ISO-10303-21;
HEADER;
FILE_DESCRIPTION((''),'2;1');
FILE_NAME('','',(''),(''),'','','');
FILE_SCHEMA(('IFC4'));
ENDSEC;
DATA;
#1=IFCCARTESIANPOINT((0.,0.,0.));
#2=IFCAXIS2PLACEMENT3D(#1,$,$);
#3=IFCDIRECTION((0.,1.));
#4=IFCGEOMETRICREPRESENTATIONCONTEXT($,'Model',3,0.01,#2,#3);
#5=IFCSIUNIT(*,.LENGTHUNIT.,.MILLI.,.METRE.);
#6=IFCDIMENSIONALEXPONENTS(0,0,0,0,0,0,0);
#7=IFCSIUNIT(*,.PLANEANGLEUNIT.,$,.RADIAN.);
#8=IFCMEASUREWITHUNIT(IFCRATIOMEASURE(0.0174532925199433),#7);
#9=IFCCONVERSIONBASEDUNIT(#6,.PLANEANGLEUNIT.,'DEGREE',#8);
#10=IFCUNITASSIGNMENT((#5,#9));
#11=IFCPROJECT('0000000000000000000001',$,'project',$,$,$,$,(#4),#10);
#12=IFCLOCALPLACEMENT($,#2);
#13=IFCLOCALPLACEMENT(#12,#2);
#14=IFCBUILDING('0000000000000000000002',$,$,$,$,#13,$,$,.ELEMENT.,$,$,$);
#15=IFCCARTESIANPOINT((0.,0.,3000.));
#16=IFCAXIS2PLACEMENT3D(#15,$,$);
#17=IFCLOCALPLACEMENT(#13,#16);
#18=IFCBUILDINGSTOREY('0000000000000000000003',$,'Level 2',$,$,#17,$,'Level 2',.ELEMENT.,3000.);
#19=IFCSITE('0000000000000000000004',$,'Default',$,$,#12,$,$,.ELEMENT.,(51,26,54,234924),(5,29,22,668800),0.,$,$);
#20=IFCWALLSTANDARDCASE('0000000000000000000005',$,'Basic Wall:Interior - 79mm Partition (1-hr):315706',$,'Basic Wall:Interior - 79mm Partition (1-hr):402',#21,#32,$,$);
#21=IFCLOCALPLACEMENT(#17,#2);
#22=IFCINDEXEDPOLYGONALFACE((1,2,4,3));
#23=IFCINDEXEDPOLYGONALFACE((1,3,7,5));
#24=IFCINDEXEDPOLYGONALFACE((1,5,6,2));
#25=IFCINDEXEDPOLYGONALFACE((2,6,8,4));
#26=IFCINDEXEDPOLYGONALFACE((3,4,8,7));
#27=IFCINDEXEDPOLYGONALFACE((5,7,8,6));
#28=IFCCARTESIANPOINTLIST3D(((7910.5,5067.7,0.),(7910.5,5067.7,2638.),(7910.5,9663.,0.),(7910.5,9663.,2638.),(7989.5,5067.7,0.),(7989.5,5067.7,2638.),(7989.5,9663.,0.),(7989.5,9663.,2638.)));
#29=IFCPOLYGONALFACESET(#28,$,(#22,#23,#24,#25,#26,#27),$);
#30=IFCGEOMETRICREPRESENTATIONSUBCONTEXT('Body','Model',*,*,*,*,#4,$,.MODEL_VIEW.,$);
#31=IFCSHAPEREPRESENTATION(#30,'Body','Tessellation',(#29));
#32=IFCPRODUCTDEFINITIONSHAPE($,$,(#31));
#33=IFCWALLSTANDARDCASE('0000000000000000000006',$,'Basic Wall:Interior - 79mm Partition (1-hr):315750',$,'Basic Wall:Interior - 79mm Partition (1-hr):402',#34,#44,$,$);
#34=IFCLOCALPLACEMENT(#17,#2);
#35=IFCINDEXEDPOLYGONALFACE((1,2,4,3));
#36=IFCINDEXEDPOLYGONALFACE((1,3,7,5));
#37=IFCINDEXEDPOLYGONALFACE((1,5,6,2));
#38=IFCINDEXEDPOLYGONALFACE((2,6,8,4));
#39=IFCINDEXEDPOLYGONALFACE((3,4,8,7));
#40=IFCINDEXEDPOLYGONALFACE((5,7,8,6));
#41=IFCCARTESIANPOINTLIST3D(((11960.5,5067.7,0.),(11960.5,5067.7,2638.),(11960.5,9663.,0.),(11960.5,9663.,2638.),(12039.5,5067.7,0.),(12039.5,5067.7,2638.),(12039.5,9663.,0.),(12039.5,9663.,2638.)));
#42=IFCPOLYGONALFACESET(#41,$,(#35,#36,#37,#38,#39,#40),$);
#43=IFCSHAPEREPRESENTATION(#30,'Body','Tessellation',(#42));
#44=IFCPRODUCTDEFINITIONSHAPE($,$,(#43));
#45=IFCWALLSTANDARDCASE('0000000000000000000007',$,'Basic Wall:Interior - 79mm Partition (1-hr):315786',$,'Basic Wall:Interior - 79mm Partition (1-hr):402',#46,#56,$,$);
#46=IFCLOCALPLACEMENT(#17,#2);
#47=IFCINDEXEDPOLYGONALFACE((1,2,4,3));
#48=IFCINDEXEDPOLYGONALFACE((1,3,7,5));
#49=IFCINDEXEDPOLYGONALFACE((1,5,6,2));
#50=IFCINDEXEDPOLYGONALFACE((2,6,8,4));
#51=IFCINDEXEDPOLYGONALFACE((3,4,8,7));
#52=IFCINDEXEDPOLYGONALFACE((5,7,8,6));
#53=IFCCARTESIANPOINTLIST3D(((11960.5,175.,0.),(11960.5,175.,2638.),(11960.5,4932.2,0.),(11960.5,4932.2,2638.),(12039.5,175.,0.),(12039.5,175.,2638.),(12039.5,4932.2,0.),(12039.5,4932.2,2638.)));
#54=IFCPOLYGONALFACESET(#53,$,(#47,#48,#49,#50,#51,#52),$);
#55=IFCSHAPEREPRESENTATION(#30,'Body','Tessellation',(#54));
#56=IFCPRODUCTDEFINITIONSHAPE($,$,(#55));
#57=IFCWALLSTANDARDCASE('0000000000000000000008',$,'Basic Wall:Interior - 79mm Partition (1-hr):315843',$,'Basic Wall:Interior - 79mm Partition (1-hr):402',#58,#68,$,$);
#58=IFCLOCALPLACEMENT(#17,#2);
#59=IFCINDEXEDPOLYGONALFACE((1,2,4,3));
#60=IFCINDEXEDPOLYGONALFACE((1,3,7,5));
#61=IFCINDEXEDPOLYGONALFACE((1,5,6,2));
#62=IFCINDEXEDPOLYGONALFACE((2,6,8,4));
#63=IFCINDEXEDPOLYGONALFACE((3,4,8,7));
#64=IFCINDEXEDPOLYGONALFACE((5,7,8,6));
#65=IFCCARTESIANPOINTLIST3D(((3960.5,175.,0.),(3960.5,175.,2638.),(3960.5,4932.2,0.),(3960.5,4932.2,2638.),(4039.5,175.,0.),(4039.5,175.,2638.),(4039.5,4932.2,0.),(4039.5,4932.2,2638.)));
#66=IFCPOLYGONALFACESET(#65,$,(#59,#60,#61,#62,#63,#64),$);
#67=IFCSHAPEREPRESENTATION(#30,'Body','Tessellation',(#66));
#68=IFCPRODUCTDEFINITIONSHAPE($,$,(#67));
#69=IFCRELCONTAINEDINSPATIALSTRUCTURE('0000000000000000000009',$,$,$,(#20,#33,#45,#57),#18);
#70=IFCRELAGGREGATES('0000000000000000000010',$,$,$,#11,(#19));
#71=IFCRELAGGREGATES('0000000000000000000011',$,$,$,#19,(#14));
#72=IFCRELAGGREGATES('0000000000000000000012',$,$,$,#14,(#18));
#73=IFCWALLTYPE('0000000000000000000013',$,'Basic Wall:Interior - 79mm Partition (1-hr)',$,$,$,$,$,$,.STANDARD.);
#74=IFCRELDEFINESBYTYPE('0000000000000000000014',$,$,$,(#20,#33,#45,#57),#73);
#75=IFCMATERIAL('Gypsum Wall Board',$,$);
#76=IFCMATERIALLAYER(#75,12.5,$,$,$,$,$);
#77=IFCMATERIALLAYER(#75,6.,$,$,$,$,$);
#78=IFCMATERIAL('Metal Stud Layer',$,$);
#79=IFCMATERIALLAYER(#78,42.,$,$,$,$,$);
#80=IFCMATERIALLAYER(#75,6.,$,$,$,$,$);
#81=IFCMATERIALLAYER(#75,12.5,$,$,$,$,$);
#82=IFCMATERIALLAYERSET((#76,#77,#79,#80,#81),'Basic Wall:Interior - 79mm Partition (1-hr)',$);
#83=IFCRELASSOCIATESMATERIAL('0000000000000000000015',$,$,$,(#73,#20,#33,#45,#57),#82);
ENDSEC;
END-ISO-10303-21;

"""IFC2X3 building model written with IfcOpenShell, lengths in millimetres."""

from ifc_helpers import new_model, entity, si_unit, converted_unit, direction, frame, frame_2d, origin, place, context, subcontext, project, spatial, polyline, rectangle, extrude, clip, bounded_halfspace, material, layer, layer_set, layer_usage, type_object, element, save


model = new_model("IFC2X3")

# Units and contexts
model_context = context("Model", 3, precision=0.01, world=origin(), true_north=direction((0.0, 1.0)))
body_context = subcontext(model_context, "Body", "Model", "MODEL_VIEW")
ifc_project = project(units=[si_unit("LENGTHUNIT", "METRE", prefix="MILLI"), converted_unit("PLANEANGLEUNIT", "DEGREE", entity("IfcRatioMeasure", 0.0174532925199433), si_unit("PLANEANGLEUNIT", "RADIAN"), dimensions=[0, 0, 0, 0, 0, 0, 0])], contexts=[model_context])

# Site, building, storey
site_placement = place(None, origin())
site = spatial("IfcSite", under=ifc_project, at=site_placement, Name="Default", CompositionType="ELEMENT", RefLatitude=(51, 26, 54, 234924), RefLongitude=(5, 29, 22, 668800), RefElevation=0.0)
building_placement = place(site_placement, origin())
building = spatial("IfcBuilding", under=site, at=building_placement, CompositionType="ELEMENT")
storey_placement = place(building_placement, frame((0.0, 0.0, 3000.0)))
storey = spatial("IfcBuildingStorey", under=building, at=storey_placement, Name="Level 2", LongName="Level 2", CompositionType="ELEMENT", Elevation=3000.0)

# Walls
ifc_material_1 = material(Name="Gypsum Wall Board")
ifc_material_2 = material(Name="Metal Stud Layer")
ifc_layer_1 = layer(ifc_material_1, 12.5)
ifc_layer_2 = layer(ifc_material_1, 6.0)
ifc_layer_3 = layer(ifc_material_2, 42.0)
ifc_layer_4 = layer(ifc_material_1, 6.0)
ifc_layer_5 = layer(ifc_material_1, 12.5)
ifc_layer_set_1 = layer_set([ifc_layer_1, ifc_layer_2, ifc_layer_3, ifc_layer_4, ifc_layer_5], Name="Basic Wall:Interior - 79mm Partition (1-hr)")
ifc_layer_usage_1 = layer_usage(ifc_layer_set_1, "AXIS2", "NEGATIVE", 39.5)
wall_type_1 = type_object("IfcWallType", Name="Basic Wall:Interior - 79mm Partition (1-hr)", PredefinedType="STANDARD", material=ifc_layer_set_1)
wall_1_placement = place(storey_placement, frame((7950.0, 5067.7, 0.0), z_axis=(0.0, 0.0, 1.0), x_axis=(0.0, 1.0, 0.0)))
element("IfcWallStandardCase", 1, at=wall_1_placement, inside=storey, type_object=wall_type_1, material=ifc_layer_usage_1, Name="Basic Wall:Interior - 79mm Partition (1-hr):315706", ObjectType="Basic Wall:Interior - 79mm Partition (1-hr):402", context=body_context, shape_type="Clipping", body=[
    clip(extrude(rectangle(XDim=4595.3, YDim=79.0, at=frame_2d((2297.6, 0.0), x_axis=(-1.0, 0.0))), origin(), (0.0, 0.0, 1.0), 2638.0), bounded_halfspace(frame((0.0, -39.5, 2638.0), z_axis=(0.0, 0.0, -1.0), x_axis=(0.0, -1.0, 0.0)), True, frame((0.0, -39.5, 2638.0)), polyline([(0.0, 0.0), (4595.3, 0.0), (4595.3, 79.0), (0.0, 79.0), (0.0, 0.0)]))),
])
ifc_layer_usage_2 = layer_usage(ifc_layer_set_1, "AXIS2", "NEGATIVE", 39.5)
wall_2_placement = place(storey_placement, frame((12000.0, 9663.0, 0.0), z_axis=(0.0, 0.0, 1.0), x_axis=(0.0, -1.0, 0.0)))
element("IfcWallStandardCase", 2, at=wall_2_placement, inside=storey, type_object=wall_type_1, material=ifc_layer_usage_2, Name="Basic Wall:Interior - 79mm Partition (1-hr):315750", ObjectType="Basic Wall:Interior - 79mm Partition (1-hr):402", context=body_context, shape_type="Clipping", body=[
    clip(extrude(rectangle(XDim=4595.3, YDim=79.0, at=frame_2d((2297.6, 0.0), x_axis=(-1.0, 0.0))), origin(), (0.0, 0.0, 1.0), 2638.0), bounded_halfspace(frame((0.0, -39.5, 2638.0), z_axis=(0.0, 0.0, -1.0), x_axis=(0.0, 1.0, 0.0)), True, frame((0.0, -39.5, 2638.0)), polyline([(0.0, 0.0), (4595.3, 0.0), (4595.3, 79.0), (0.0, 79.0), (0.0, 0.0)]))),
])
ifc_layer_usage_3 = layer_usage(ifc_layer_set_1, "AXIS2", "NEGATIVE", 39.5)
wall_3_placement = place(storey_placement, frame((12000.0, 4932.2, 0.0), z_axis=(0.0, 0.0, 1.0), x_axis=(0.0, -1.0, 0.0)))
element("IfcWallStandardCase", 3, at=wall_3_placement, inside=storey, type_object=wall_type_1, material=ifc_layer_usage_3, Name="Basic Wall:Interior - 79mm Partition (1-hr):315786", ObjectType="Basic Wall:Interior - 79mm Partition (1-hr):402", context=body_context, shape_type="Clipping", body=[
    clip(extrude(rectangle(XDim=4757.3, YDim=79.0, at=frame_2d((2378.6, 0.0), x_axis=(-1.0, 0.0))), origin(), (0.0, 0.0, 1.0), 2638.0), bounded_halfspace(frame((0.0, -39.5, 2638.0), z_axis=(0.0, 0.0, -1.0), x_axis=(0.0, 1.0, 0.0)), True, frame((0.0, -39.5, 2638.0)), polyline([(0.0, 0.0), (4757.3, 0.0), (4757.3, 79.0), (0.0, 79.0), (0.0, 0.0)]))),
])
ifc_layer_usage_4 = layer_usage(ifc_layer_set_1, "AXIS2", "NEGATIVE", 39.5)
wall_4_placement = place(storey_placement, frame((4000.0, 4932.2, 0.0), z_axis=(0.0, 0.0, 1.0), x_axis=(0.0, -1.0, 0.0)))
element("IfcWallStandardCase", 4, at=wall_4_placement, inside=storey, type_object=wall_type_1, material=ifc_layer_usage_4, Name="Basic Wall:Interior - 79mm Partition (1-hr):315843", ObjectType="Basic Wall:Interior - 79mm Partition (1-hr):402", context=body_context, shape_type="Clipping", body=[
    clip(extrude(rectangle(XDim=4757.2, YDim=79.0, at=frame_2d((2378.6, 0.0), x_axis=(-1.0, 0.0))), origin(), (0.0, 0.0, 1.0), 2638.0), bounded_halfspace(frame((0.0, -39.5, 2638.0), z_axis=(0.0, 0.0, -1.0), x_axis=(0.0, 1.0, 0.0)), True, frame((0.0, -39.5, 2638.0)), polyline([(0.0, 0.0), (4757.2, 0.0), (4757.2, 79.0), (0.0, 79.0), (0.0, 0.0)]))),
])

save(model, "model.ifc")
